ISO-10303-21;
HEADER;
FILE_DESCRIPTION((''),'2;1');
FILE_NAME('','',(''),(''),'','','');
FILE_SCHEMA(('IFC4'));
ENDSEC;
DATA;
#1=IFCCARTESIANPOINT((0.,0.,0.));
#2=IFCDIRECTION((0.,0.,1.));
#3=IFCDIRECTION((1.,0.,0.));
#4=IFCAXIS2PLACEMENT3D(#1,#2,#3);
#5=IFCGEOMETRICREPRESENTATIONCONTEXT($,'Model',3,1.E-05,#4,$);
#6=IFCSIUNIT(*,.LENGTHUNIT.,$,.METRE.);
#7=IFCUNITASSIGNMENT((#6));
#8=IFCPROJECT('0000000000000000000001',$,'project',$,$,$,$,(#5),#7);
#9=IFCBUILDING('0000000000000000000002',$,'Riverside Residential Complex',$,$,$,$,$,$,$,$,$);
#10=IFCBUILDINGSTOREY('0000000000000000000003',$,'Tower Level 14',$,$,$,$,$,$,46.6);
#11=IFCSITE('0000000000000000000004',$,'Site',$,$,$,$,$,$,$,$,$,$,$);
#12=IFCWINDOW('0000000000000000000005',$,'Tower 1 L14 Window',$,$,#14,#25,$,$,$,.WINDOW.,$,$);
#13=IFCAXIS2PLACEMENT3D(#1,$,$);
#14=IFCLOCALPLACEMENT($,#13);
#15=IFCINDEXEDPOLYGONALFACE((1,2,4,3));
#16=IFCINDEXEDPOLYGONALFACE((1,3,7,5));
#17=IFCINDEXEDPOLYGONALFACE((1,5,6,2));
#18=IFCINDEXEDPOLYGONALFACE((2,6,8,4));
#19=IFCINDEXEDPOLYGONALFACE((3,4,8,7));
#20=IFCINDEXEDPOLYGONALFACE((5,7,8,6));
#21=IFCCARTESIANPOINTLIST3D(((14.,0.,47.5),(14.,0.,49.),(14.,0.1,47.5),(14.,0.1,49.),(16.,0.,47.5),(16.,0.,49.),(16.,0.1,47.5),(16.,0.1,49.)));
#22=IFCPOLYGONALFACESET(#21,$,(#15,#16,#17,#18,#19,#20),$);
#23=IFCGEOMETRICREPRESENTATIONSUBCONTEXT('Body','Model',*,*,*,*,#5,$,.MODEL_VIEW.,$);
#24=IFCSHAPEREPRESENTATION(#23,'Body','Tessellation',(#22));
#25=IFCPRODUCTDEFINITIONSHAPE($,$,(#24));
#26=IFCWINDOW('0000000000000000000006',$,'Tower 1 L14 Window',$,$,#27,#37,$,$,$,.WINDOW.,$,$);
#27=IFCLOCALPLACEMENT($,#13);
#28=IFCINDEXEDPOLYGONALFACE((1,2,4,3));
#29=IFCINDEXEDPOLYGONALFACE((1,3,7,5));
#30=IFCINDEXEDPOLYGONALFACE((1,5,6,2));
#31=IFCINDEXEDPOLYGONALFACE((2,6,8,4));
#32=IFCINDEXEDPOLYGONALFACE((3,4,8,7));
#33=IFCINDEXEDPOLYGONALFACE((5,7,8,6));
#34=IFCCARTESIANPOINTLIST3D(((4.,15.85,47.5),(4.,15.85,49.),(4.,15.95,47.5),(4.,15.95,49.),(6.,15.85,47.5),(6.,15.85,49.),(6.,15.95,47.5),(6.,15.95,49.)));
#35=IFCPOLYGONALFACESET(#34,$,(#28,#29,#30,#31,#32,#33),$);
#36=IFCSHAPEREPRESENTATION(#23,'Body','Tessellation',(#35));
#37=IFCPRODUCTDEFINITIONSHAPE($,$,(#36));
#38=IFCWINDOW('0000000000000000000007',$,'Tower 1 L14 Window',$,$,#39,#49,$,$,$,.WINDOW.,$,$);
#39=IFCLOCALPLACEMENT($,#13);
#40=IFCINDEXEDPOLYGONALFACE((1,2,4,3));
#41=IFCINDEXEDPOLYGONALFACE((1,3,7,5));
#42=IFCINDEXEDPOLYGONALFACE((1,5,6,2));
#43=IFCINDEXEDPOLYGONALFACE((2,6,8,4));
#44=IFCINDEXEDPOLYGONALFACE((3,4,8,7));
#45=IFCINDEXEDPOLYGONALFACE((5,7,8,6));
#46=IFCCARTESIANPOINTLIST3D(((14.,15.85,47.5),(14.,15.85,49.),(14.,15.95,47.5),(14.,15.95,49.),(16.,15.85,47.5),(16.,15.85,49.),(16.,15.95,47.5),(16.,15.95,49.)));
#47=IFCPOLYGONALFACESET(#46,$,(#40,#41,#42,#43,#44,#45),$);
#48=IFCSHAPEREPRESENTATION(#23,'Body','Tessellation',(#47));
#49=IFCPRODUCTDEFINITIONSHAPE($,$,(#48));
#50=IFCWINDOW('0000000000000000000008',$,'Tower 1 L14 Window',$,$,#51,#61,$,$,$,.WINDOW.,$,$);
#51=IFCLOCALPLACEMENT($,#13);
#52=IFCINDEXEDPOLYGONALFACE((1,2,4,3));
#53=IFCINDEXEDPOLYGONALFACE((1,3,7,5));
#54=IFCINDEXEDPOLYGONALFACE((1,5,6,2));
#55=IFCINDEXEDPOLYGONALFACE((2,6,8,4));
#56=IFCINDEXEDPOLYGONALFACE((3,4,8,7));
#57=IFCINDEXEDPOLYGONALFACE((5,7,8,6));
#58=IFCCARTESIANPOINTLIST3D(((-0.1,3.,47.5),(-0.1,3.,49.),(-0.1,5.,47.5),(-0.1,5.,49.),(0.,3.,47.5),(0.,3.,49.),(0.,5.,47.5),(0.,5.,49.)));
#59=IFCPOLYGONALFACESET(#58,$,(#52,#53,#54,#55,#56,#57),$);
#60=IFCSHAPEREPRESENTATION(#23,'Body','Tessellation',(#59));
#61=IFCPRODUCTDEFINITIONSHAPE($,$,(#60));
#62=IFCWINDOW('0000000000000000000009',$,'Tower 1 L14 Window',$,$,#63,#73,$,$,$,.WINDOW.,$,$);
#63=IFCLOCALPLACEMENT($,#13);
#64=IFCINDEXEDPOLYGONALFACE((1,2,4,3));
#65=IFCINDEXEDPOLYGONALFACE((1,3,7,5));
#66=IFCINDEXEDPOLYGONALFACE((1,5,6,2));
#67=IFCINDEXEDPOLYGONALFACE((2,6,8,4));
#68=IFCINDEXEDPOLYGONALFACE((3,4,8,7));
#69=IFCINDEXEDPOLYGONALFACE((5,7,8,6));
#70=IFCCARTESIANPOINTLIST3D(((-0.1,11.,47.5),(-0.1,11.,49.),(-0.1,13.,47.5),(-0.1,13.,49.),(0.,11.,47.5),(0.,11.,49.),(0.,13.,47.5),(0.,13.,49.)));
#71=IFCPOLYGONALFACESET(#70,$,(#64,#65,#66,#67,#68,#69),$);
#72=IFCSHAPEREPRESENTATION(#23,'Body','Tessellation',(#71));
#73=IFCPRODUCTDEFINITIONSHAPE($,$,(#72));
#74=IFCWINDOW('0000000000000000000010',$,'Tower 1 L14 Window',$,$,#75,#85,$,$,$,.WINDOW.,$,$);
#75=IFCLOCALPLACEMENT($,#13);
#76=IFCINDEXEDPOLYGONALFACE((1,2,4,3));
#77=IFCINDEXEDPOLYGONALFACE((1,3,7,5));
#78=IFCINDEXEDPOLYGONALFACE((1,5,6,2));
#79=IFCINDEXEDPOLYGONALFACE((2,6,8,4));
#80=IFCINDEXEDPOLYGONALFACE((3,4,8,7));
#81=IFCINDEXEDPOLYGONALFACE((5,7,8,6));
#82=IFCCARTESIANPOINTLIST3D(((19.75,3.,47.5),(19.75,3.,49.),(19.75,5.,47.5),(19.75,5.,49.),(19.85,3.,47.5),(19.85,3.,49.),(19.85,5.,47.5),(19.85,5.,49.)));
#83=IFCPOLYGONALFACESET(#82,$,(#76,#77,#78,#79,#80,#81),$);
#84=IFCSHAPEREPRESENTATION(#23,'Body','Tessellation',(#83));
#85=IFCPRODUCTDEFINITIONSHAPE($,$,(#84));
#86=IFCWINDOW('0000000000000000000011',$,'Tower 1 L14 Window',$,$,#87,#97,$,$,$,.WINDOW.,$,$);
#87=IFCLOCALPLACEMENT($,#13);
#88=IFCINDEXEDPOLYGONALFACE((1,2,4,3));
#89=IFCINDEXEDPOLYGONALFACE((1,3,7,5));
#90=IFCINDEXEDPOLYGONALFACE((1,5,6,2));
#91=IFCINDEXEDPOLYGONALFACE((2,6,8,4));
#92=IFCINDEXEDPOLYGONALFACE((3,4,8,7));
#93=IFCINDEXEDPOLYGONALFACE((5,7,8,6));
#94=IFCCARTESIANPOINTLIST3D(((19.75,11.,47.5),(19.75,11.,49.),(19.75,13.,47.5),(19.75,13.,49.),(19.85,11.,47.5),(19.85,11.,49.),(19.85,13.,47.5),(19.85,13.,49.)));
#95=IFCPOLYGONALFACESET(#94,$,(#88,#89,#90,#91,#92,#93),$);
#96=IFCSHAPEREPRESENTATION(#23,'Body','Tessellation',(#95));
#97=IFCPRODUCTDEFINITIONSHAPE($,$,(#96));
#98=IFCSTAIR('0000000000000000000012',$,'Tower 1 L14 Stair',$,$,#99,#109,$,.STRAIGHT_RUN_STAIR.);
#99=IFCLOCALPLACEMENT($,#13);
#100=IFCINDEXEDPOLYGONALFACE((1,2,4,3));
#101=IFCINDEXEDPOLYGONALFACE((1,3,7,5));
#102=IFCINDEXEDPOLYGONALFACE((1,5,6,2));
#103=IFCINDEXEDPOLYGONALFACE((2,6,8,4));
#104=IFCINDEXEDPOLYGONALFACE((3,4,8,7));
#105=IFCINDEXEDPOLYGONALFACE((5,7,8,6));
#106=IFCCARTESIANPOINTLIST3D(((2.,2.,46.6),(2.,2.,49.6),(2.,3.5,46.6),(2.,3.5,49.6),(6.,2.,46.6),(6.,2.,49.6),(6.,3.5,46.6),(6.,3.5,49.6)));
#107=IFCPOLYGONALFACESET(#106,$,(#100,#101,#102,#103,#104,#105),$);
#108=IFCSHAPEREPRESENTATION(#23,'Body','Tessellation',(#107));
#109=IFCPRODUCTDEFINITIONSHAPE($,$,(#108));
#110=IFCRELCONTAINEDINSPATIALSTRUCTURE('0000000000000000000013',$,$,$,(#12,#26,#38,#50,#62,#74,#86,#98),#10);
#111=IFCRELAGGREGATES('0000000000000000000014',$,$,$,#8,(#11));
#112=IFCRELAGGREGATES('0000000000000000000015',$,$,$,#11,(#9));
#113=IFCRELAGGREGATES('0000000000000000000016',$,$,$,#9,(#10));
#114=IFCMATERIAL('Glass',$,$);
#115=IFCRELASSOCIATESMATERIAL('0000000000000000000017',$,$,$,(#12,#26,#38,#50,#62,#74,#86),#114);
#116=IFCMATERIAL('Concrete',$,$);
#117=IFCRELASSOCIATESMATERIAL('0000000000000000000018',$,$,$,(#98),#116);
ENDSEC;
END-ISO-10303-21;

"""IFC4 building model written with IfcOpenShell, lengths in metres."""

from ifc_helpers import new_model, si_unit, frame, origin_with_axes, place, context, subcontext, project, spatial, line, indexed_curve, outline, extrude, material, element, save


model = new_model("IFC4")

# Units and contexts
model_context = context("Model", 3, precision=1e-05, world=origin_with_axes())
body_context = subcontext(model_context, "Body", "Model", "MODEL_VIEW")
ifc_project = project(units=[si_unit("LENGTHUNIT", "METRE")], contexts=[model_context])

# Site, building, storey
site = spatial("IfcSite", under=ifc_project, Name="Site")
building = spatial("IfcBuilding", under=site, Name="Riverside Residential Complex")
storey = spatial("IfcBuildingStorey", under=building, Name="Tower Level 14", Elevation=46.6)

# Shared definitions
ifc_material_1 = material(Name="Concrete")

# Windows
ifc_material_2 = material(Name="Glass")
for number, where, z_axis, x_axis, name in (
    (1, (14.0, 0.0, 47.5), (0.0, 0.0, 1.0), (1.0, 0.0, 0.0), "Tower 1 L14 Window"),
    (2, (4.0, 15.85, 47.5), (0.0, 0.0, 1.0), (1.0, 0.0, 0.0), "Tower 1 L14 Window"),
    (3, (14.0, 15.85, 47.5), (0.0, 0.0, 1.0), (1.0, 0.0, 0.0), "Tower 1 L14 Window"),
    (4, (0.0, 3.0, 47.5), (0.0, 0.0, 1.0), (0.0, 1.0, 0.0), "Tower 1 L14 Window"),
    (5, (0.0, 11.0, 47.5), (0.0, 0.0, 1.0), (0.0, 1.0, 0.0), "Tower 1 L14 Window"),
    (6, (19.85, 3.0, 47.5), (0.0, 0.0, 1.0), (0.0, 1.0, 0.0), "Tower 1 L14 Window"),
    (7, (19.85, 11.0, 47.5), (0.0, 0.0, 1.0), (0.0, 1.0, 0.0), "Tower 1 L14 Window"),
):
    element("IfcWindow", number, at=place(None, frame(where, z_axis=z_axis, x_axis=x_axis)), inside=storey, material=ifc_material_2, Name=name, PredefinedType="WINDOW", context=body_context, shape_type="SweptSolid", body=[
        extrude(outline(indexed_curve([(0.0, 0.0), (2.0, 0.0), (2.0, 0.1), (0.0, 0.1)], segments=[line(1, 2, 3, 4, 1)])), origin_with_axes(), (0.0, 0.0, 1.0), 1.5),
    ])

# Stair
stair_placement = place(None, frame((2.0, 2.0, 46.6), z_axis=(0.0, 0.0, 1.0), x_axis=(1.0, 0.0, 0.0)))
element("IfcStair", 8, at=stair_placement, inside=storey, material=ifc_material_1, Name="Tower 1 L14 Stair", PredefinedType="STRAIGHT_RUN_STAIR", context=body_context, shape_type="SweptSolid", body=[
    extrude(outline(indexed_curve([(0.0, 0.0), (4.0, 0.0), (4.0, 1.5), (0.0, 1.5)], segments=[line(1, 2, 3, 4, 1)])), origin_with_axes(), (0.0, 0.0, 1.0), 3.0),
])

save(model, "model.ifc")
